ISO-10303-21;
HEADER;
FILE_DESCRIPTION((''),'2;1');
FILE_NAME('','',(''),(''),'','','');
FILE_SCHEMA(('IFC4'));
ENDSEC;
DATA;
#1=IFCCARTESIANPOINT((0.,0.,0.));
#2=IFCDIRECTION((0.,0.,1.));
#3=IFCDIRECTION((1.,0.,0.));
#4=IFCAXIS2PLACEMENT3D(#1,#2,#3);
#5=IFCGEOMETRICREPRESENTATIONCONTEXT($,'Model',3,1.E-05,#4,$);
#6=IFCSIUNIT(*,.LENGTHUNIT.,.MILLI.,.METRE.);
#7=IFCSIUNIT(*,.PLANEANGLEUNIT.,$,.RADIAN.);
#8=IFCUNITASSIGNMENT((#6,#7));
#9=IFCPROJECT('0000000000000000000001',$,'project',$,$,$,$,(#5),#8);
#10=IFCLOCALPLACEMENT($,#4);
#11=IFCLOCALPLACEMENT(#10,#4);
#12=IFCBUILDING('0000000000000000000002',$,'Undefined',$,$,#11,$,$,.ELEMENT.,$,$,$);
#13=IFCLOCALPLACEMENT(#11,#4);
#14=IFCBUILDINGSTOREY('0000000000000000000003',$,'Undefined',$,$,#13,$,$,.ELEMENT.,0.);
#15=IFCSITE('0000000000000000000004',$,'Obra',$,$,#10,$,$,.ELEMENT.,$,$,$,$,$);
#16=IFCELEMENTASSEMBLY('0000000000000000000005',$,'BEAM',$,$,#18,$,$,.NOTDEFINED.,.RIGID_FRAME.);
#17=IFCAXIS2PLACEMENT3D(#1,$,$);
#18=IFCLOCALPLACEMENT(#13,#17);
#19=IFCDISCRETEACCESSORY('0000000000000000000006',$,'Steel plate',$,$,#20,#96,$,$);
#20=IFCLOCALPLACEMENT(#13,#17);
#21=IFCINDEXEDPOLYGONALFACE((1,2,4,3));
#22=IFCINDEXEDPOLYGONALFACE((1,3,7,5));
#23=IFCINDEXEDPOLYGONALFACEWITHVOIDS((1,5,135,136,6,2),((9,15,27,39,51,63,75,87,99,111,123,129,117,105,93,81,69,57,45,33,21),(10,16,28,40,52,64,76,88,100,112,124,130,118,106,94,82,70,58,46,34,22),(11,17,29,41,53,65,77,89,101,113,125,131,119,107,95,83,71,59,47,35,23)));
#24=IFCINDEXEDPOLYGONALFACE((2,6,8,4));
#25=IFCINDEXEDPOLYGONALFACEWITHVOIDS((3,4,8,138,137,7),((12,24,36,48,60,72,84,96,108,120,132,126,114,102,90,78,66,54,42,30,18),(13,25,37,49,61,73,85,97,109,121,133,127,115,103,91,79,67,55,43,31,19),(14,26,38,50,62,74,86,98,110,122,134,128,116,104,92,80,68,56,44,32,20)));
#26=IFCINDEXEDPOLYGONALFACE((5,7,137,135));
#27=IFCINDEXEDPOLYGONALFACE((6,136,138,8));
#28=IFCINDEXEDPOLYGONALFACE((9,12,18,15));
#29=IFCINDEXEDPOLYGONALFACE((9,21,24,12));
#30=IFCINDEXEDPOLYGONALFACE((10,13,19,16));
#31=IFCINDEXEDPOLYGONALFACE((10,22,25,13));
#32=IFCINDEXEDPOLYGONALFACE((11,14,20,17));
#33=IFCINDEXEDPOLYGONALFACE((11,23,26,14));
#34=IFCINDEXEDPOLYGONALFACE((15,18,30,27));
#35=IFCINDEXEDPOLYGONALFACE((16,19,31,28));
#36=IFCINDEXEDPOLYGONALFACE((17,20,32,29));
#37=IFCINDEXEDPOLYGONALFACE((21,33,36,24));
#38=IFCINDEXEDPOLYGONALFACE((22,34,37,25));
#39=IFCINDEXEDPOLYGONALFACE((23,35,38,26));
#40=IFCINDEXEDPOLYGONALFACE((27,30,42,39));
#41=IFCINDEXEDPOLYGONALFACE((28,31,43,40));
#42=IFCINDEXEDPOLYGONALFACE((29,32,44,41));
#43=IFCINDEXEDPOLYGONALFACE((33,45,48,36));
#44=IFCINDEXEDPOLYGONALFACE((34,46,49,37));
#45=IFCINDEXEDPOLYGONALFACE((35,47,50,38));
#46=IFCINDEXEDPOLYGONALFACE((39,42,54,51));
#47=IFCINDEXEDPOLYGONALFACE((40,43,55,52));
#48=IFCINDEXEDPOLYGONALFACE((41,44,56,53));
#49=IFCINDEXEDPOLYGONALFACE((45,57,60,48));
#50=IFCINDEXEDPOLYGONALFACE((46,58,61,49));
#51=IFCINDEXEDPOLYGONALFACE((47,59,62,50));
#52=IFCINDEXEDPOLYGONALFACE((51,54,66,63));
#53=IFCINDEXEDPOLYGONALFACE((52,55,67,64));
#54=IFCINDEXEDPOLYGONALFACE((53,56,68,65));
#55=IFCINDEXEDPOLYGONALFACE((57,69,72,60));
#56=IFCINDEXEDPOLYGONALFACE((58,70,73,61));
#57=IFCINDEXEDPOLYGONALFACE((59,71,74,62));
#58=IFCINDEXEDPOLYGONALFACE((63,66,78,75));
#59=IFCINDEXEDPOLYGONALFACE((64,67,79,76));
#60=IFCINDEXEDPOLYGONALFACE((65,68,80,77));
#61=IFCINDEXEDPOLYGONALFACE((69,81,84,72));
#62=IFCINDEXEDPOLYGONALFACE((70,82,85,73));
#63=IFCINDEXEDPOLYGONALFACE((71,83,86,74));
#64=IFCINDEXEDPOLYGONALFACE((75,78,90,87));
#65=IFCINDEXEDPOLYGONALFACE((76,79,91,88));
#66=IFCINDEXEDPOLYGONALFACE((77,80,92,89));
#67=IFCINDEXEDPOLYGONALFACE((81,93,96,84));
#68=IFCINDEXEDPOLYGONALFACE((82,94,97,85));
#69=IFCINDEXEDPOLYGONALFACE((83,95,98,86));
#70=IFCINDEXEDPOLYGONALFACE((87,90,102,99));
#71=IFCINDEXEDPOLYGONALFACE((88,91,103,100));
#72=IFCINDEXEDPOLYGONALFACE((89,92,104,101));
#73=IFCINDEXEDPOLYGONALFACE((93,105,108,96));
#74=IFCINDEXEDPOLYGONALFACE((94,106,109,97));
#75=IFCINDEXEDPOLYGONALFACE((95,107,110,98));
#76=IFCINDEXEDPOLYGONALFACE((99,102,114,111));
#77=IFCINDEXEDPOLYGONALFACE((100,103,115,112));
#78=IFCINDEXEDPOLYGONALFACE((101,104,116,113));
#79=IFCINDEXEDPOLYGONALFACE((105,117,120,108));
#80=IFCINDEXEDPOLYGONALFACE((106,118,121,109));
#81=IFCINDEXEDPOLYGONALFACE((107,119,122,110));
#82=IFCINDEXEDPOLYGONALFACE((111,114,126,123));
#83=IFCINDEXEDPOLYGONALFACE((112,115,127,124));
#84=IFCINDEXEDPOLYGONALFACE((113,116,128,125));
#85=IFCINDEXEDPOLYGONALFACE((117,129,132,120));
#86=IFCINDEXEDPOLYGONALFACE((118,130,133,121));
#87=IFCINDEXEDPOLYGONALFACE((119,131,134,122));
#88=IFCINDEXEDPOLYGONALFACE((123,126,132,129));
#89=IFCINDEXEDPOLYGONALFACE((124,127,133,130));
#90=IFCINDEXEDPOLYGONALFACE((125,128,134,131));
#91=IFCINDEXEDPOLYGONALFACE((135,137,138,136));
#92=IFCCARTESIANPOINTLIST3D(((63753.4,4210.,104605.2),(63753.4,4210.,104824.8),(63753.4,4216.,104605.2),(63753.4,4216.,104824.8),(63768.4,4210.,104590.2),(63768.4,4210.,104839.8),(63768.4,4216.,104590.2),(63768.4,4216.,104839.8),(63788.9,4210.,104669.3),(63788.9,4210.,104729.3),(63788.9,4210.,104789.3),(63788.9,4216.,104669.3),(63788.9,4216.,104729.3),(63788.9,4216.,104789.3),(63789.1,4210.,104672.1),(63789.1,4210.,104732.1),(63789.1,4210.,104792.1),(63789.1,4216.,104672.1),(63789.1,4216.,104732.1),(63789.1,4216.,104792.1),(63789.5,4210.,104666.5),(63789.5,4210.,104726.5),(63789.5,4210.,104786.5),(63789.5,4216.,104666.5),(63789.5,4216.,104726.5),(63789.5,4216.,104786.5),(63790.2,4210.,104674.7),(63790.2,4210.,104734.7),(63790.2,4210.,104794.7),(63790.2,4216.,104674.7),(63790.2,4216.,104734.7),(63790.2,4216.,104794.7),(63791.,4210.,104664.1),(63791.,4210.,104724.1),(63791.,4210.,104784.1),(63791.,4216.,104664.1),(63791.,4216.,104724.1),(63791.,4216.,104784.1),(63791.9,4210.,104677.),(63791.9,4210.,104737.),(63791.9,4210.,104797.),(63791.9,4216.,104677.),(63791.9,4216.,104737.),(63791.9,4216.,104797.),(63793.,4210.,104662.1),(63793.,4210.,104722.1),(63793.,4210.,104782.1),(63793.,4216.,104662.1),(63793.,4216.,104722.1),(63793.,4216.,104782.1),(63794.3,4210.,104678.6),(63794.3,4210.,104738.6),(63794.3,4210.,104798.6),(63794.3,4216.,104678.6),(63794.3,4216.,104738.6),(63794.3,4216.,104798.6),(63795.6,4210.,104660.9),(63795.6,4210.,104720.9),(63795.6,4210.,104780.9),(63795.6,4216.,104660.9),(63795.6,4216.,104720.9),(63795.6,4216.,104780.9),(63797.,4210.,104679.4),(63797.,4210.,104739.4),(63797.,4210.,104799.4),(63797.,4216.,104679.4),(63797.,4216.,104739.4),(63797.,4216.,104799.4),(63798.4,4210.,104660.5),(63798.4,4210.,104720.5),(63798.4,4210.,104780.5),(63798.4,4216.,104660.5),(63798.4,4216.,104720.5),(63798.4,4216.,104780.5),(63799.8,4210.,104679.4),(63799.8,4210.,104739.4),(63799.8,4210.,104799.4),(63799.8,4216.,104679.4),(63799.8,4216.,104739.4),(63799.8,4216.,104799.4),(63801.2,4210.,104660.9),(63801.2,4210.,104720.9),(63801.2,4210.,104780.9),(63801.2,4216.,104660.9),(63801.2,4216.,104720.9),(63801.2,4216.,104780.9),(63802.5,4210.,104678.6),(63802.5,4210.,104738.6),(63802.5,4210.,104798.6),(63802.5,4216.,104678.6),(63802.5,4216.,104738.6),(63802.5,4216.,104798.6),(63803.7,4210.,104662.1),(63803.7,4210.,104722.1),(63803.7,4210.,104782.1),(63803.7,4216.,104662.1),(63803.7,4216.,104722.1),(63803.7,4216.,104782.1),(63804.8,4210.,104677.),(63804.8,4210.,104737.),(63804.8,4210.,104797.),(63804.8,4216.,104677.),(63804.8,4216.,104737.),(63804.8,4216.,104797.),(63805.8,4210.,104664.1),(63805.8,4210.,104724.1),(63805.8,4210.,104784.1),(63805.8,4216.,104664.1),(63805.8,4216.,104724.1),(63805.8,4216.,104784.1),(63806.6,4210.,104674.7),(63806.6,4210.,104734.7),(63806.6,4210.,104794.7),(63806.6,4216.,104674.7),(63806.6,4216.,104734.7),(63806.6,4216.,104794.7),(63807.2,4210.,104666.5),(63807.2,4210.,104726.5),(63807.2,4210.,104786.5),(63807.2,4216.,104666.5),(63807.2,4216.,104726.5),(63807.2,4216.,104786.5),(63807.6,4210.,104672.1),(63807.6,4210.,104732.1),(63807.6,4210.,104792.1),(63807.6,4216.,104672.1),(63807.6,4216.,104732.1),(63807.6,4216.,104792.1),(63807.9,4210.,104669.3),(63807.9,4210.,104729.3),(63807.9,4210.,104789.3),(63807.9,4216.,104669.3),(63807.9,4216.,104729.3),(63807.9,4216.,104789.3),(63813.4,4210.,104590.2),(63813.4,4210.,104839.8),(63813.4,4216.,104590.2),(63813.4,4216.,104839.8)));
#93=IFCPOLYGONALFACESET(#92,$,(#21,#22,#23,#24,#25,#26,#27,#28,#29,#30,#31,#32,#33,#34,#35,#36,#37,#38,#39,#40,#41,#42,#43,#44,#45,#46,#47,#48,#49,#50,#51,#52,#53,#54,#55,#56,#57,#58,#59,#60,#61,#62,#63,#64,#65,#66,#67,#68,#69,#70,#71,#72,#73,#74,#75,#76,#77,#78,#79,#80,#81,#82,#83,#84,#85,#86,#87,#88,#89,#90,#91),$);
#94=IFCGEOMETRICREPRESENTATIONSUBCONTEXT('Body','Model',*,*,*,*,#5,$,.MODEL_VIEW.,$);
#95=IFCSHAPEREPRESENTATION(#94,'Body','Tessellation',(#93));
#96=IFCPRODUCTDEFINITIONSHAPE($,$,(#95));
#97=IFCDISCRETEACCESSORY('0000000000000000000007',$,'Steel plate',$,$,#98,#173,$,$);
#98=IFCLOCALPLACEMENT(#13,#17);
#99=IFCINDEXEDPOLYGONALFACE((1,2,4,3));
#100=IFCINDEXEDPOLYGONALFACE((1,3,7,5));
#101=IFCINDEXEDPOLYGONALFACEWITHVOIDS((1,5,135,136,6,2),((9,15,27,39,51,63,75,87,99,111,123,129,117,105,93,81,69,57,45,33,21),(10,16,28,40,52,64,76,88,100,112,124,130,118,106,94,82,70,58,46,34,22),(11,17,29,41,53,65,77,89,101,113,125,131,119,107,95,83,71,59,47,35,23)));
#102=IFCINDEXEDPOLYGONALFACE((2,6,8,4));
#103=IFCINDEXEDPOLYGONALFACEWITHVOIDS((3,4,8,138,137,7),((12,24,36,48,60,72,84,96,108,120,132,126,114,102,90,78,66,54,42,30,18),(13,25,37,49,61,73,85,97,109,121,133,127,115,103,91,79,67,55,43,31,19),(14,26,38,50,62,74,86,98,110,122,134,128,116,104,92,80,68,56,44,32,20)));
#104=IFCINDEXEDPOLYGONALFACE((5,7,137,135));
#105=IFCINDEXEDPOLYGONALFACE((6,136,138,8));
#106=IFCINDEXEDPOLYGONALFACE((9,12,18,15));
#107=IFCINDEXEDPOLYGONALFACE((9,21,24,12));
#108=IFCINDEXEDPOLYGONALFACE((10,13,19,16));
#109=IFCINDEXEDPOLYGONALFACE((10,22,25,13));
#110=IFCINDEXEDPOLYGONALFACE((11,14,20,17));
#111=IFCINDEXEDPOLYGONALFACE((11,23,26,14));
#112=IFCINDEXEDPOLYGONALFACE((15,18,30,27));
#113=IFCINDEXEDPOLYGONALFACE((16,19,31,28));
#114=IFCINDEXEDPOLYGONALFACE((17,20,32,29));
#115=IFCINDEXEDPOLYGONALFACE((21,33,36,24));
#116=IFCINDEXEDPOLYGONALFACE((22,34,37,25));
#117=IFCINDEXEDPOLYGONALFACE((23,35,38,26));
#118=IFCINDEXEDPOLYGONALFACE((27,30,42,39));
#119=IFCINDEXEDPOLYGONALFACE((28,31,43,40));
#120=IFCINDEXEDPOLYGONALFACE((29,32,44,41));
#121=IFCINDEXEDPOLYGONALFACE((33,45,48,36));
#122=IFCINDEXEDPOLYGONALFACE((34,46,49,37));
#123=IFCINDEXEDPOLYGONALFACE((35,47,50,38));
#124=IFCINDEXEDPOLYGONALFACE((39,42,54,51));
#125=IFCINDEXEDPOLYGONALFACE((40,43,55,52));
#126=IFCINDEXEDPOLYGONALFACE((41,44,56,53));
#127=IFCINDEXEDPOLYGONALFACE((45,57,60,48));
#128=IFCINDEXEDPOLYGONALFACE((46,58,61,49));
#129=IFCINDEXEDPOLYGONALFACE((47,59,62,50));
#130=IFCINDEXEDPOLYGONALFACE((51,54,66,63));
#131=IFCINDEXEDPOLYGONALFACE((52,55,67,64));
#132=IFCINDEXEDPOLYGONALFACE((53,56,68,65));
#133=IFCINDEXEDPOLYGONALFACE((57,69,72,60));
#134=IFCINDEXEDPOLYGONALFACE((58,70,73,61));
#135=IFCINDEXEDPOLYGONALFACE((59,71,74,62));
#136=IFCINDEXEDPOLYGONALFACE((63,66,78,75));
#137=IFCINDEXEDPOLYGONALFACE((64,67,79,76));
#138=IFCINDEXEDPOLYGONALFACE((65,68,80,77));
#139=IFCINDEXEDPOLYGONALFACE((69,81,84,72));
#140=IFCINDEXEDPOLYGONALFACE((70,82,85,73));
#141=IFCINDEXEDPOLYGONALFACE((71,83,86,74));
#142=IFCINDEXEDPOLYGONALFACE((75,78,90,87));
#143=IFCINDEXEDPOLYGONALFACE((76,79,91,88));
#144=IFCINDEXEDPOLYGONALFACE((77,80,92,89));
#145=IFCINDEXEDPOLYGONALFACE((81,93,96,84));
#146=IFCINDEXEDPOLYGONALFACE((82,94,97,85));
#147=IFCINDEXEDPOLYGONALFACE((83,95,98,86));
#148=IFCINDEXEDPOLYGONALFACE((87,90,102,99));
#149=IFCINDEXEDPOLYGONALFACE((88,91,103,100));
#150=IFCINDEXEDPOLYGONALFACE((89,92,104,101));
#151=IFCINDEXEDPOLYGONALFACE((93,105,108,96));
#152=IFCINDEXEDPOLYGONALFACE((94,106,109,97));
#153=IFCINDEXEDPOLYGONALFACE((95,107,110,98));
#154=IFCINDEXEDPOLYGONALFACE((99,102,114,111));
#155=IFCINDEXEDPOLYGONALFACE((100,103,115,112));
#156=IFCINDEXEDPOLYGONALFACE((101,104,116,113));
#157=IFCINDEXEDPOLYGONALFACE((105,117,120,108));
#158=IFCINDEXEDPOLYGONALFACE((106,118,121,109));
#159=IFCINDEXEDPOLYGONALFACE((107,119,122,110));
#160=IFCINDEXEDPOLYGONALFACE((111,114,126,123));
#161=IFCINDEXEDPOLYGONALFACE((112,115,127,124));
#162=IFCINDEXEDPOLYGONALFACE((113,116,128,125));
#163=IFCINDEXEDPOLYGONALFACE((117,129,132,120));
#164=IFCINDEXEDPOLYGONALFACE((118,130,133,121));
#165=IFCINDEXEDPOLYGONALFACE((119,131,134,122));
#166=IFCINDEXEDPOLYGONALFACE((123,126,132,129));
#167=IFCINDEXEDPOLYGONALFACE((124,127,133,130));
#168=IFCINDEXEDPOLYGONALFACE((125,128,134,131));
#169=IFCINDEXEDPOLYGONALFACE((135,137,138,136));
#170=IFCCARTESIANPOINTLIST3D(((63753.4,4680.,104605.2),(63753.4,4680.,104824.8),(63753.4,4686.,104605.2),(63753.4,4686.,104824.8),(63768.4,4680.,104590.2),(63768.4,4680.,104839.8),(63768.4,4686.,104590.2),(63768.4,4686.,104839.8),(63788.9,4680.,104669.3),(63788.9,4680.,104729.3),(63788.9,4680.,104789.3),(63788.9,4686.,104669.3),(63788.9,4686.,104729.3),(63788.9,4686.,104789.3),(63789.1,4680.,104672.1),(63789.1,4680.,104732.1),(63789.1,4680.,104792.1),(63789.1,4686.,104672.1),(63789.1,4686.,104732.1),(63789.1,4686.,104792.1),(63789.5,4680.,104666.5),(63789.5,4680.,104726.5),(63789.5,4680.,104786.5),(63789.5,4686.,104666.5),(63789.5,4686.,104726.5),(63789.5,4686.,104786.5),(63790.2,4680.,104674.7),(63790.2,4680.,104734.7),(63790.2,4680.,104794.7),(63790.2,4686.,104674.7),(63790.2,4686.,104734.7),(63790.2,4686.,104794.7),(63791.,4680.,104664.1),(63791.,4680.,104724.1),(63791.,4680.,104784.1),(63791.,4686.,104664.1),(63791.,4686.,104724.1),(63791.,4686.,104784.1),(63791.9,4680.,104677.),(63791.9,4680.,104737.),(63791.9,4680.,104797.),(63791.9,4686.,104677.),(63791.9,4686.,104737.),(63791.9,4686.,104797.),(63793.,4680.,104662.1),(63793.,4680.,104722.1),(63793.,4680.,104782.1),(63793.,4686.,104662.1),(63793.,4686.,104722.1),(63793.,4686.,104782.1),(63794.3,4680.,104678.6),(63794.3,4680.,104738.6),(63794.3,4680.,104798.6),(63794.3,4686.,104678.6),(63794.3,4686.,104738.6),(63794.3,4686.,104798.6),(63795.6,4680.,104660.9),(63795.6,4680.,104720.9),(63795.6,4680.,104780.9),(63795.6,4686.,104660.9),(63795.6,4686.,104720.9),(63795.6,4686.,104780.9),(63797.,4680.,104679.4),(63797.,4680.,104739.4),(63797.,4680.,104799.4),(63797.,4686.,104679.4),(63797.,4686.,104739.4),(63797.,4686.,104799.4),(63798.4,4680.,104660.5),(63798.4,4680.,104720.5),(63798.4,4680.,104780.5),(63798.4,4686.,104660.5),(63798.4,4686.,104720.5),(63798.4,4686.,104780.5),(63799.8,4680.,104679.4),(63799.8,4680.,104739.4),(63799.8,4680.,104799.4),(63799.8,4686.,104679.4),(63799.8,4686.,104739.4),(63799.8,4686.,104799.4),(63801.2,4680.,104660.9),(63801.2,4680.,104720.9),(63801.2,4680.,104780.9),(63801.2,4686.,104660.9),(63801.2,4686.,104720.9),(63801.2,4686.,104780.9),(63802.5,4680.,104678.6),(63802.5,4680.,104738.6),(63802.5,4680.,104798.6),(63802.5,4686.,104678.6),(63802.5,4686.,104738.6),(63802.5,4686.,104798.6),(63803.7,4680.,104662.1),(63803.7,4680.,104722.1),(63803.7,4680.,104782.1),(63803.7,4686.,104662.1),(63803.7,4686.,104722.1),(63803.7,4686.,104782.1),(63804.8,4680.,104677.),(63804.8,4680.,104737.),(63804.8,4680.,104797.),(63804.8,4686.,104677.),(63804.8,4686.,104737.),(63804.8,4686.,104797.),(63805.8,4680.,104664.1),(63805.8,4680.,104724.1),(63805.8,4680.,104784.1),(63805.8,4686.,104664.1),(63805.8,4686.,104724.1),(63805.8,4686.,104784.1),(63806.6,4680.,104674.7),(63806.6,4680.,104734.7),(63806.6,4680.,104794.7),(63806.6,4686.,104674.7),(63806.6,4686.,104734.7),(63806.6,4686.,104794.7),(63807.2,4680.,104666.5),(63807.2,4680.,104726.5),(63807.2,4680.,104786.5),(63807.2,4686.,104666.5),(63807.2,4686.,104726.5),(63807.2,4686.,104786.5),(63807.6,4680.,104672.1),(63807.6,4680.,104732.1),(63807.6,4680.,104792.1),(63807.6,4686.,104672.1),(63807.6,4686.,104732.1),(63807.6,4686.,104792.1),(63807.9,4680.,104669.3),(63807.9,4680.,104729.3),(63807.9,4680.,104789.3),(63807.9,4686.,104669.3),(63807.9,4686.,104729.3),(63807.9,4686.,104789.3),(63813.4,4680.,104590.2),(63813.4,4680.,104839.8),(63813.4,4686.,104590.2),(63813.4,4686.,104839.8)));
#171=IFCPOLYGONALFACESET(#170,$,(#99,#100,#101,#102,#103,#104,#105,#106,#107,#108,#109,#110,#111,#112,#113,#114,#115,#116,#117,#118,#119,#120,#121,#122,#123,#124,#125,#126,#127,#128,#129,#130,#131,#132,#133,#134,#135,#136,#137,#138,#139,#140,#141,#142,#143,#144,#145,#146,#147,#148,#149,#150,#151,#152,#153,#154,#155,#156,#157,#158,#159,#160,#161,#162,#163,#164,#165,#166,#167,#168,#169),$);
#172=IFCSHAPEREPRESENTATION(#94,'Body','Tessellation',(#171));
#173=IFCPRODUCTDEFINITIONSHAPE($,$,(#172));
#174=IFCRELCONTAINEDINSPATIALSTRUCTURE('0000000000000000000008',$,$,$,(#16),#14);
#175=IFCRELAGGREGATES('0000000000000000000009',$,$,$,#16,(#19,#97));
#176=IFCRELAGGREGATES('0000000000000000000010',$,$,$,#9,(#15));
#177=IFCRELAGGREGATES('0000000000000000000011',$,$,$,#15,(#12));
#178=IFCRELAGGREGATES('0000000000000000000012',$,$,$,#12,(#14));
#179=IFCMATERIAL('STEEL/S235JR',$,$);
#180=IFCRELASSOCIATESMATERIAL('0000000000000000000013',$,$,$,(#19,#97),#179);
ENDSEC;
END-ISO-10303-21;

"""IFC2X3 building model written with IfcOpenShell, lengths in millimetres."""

from ifc_helpers import new_model, si_unit, frame, origin_with_axes, origin_2d_with_axis, place, context, subcontext, project, spatial, polyline, circle, outline, extrude, source, transform, mapped, material, element, aggregate, save


model = new_model("IFC2X3")

# Units and contexts
model_context = context("Model", 3, precision=1e-05, world=origin_with_axes())
body_context = subcontext(model_context, "Body", "Model", "MODEL_VIEW")
ifc_project = project(units=[si_unit("LENGTHUNIT", "METRE", prefix="MILLI"), si_unit("PLANEANGLEUNIT", "RADIAN")], contexts=[model_context])

# Site, building, storey
site_placement = place(None, origin_with_axes())
site = spatial("IfcSite", under=ifc_project, at=site_placement, Name="Obra", CompositionType="ELEMENT")
building_placement = place(site_placement, origin_with_axes())
building = spatial("IfcBuilding", under=site, at=building_placement, Name="Undefined", CompositionType="ELEMENT")
storey_placement = place(building_placement, origin_with_axes())
storey = spatial("IfcBuildingStorey", under=building, at=storey_placement, Name="Undefined", CompositionType="ELEMENT", Elevation=0.0)

# Element assembly, discrete accessories, openings
ifc_material = material(Name="STEEL/S235JR")
shared_shape_1 = source(origin_with_axes(), body_context, "Body", "SweptSolid", [
    extrude(circle(Radius=9.5, at=origin_2d_with_axis()), frame((0.0, -9.2, 0.0), z_axis=(0.0, 1.0, 0.0), x_axis=(1.0, 0.0, 0.0)), (0.0, 0.0, 1.0), 6.2),
])
assembly_1_placement = place(storey_placement, origin_with_axes())
assembly_1 = element("IfcElementAssembly", 1, at=assembly_1_placement, inside=storey, Name="BEAM", AssemblyPlace="NOTDEFINED", PredefinedType="RIGID_FRAME")
discrete_accessory_1_placement = place(assembly_1_placement, frame((63813.4, 4213.0, 104590.2), z_axis=(0.0, 1.0, 0.0), x_axis=(-1.0, 0.0, 0.0)))
discrete_accessory_1 = element("IfcDiscreteAccessory", 2, at=discrete_accessory_1_placement, material=ifc_material, Name="Steel plate", context=body_context, shape_type="SweptSolid", body=[
    extrude(outline(polyline([(0.0, 0.0), (45.0, 0.0), (60.0, 15.0), (60.0, 234.6), (45.0, 249.6), (0.0, 249.6), (0.0, 0.0)])), frame((0.0, 0.0, -3.0), z_axis=(0.0, 0.0, 1.0), x_axis=(1.0, 0.0, 0.0)), (0.0, 0.0, 1.0), 6.0),
])
opening_1_placement = place(assembly_1_placement, frame((63763.4, 4219.1, 104850.0), z_axis=(1.0, 0.0, 0.0), x_axis=(0.0, 0.0, -1.0)))
element("IfcOpeningElement", 3, at=opening_1_placement, cuts=discrete_accessory_1, ObjectType="Opening", context=body_context, shape_type="MappedRepresentation", body=[
    mapped(shared_shape_1, transform((60.0, 0.0, 35.0))),
    mapped(shared_shape_1, transform((120.0, 0.0, 35.0))),
    mapped(shared_shape_1, transform((180.0, 0.0, 35.0))),
])
discrete_accessory_2_placement = place(assembly_1_placement, frame((63813.4, 4683.0, 104590.2), z_axis=(0.0, 1.0, 0.0), x_axis=(-1.0, 0.0, 0.0)))
discrete_accessory_2 = element("IfcDiscreteAccessory", 4, at=discrete_accessory_2_placement, material=ifc_material, Name="Steel plate", context=body_context, shape_type="SweptSolid", body=[
    extrude(outline(polyline([(0.0, 0.0), (45.0, 0.0), (60.0, 15.0), (60.0, 234.6), (45.0, 249.6), (0.0, 249.6), (0.0, 0.0)])), frame((0.0, 0.0, -3.0), z_axis=(0.0, 0.0, 1.0), x_axis=(1.0, 0.0, 0.0)), (0.0, 0.0, 1.0), 6.0),
])
opening_2_placement = place(assembly_1_placement, frame((63763.4, 4689.1, 104850.0), z_axis=(1.0, 0.0, 0.0), x_axis=(0.0, 0.0, -1.0)))
element("IfcOpeningElement", 5, at=opening_2_placement, cuts=discrete_accessory_2, ObjectType="Opening", context=body_context, shape_type="MappedRepresentation", body=[
    mapped(shared_shape_1, transform((60.0, 0.0, 35.0))),
    mapped(shared_shape_1, transform((120.0, 0.0, 35.0))),
    mapped(shared_shape_1, transform((180.0, 0.0, 35.0))),
])
aggregate(assembly_1, [discrete_accessory_1, discrete_accessory_2])

save(model, "model.ifc")
